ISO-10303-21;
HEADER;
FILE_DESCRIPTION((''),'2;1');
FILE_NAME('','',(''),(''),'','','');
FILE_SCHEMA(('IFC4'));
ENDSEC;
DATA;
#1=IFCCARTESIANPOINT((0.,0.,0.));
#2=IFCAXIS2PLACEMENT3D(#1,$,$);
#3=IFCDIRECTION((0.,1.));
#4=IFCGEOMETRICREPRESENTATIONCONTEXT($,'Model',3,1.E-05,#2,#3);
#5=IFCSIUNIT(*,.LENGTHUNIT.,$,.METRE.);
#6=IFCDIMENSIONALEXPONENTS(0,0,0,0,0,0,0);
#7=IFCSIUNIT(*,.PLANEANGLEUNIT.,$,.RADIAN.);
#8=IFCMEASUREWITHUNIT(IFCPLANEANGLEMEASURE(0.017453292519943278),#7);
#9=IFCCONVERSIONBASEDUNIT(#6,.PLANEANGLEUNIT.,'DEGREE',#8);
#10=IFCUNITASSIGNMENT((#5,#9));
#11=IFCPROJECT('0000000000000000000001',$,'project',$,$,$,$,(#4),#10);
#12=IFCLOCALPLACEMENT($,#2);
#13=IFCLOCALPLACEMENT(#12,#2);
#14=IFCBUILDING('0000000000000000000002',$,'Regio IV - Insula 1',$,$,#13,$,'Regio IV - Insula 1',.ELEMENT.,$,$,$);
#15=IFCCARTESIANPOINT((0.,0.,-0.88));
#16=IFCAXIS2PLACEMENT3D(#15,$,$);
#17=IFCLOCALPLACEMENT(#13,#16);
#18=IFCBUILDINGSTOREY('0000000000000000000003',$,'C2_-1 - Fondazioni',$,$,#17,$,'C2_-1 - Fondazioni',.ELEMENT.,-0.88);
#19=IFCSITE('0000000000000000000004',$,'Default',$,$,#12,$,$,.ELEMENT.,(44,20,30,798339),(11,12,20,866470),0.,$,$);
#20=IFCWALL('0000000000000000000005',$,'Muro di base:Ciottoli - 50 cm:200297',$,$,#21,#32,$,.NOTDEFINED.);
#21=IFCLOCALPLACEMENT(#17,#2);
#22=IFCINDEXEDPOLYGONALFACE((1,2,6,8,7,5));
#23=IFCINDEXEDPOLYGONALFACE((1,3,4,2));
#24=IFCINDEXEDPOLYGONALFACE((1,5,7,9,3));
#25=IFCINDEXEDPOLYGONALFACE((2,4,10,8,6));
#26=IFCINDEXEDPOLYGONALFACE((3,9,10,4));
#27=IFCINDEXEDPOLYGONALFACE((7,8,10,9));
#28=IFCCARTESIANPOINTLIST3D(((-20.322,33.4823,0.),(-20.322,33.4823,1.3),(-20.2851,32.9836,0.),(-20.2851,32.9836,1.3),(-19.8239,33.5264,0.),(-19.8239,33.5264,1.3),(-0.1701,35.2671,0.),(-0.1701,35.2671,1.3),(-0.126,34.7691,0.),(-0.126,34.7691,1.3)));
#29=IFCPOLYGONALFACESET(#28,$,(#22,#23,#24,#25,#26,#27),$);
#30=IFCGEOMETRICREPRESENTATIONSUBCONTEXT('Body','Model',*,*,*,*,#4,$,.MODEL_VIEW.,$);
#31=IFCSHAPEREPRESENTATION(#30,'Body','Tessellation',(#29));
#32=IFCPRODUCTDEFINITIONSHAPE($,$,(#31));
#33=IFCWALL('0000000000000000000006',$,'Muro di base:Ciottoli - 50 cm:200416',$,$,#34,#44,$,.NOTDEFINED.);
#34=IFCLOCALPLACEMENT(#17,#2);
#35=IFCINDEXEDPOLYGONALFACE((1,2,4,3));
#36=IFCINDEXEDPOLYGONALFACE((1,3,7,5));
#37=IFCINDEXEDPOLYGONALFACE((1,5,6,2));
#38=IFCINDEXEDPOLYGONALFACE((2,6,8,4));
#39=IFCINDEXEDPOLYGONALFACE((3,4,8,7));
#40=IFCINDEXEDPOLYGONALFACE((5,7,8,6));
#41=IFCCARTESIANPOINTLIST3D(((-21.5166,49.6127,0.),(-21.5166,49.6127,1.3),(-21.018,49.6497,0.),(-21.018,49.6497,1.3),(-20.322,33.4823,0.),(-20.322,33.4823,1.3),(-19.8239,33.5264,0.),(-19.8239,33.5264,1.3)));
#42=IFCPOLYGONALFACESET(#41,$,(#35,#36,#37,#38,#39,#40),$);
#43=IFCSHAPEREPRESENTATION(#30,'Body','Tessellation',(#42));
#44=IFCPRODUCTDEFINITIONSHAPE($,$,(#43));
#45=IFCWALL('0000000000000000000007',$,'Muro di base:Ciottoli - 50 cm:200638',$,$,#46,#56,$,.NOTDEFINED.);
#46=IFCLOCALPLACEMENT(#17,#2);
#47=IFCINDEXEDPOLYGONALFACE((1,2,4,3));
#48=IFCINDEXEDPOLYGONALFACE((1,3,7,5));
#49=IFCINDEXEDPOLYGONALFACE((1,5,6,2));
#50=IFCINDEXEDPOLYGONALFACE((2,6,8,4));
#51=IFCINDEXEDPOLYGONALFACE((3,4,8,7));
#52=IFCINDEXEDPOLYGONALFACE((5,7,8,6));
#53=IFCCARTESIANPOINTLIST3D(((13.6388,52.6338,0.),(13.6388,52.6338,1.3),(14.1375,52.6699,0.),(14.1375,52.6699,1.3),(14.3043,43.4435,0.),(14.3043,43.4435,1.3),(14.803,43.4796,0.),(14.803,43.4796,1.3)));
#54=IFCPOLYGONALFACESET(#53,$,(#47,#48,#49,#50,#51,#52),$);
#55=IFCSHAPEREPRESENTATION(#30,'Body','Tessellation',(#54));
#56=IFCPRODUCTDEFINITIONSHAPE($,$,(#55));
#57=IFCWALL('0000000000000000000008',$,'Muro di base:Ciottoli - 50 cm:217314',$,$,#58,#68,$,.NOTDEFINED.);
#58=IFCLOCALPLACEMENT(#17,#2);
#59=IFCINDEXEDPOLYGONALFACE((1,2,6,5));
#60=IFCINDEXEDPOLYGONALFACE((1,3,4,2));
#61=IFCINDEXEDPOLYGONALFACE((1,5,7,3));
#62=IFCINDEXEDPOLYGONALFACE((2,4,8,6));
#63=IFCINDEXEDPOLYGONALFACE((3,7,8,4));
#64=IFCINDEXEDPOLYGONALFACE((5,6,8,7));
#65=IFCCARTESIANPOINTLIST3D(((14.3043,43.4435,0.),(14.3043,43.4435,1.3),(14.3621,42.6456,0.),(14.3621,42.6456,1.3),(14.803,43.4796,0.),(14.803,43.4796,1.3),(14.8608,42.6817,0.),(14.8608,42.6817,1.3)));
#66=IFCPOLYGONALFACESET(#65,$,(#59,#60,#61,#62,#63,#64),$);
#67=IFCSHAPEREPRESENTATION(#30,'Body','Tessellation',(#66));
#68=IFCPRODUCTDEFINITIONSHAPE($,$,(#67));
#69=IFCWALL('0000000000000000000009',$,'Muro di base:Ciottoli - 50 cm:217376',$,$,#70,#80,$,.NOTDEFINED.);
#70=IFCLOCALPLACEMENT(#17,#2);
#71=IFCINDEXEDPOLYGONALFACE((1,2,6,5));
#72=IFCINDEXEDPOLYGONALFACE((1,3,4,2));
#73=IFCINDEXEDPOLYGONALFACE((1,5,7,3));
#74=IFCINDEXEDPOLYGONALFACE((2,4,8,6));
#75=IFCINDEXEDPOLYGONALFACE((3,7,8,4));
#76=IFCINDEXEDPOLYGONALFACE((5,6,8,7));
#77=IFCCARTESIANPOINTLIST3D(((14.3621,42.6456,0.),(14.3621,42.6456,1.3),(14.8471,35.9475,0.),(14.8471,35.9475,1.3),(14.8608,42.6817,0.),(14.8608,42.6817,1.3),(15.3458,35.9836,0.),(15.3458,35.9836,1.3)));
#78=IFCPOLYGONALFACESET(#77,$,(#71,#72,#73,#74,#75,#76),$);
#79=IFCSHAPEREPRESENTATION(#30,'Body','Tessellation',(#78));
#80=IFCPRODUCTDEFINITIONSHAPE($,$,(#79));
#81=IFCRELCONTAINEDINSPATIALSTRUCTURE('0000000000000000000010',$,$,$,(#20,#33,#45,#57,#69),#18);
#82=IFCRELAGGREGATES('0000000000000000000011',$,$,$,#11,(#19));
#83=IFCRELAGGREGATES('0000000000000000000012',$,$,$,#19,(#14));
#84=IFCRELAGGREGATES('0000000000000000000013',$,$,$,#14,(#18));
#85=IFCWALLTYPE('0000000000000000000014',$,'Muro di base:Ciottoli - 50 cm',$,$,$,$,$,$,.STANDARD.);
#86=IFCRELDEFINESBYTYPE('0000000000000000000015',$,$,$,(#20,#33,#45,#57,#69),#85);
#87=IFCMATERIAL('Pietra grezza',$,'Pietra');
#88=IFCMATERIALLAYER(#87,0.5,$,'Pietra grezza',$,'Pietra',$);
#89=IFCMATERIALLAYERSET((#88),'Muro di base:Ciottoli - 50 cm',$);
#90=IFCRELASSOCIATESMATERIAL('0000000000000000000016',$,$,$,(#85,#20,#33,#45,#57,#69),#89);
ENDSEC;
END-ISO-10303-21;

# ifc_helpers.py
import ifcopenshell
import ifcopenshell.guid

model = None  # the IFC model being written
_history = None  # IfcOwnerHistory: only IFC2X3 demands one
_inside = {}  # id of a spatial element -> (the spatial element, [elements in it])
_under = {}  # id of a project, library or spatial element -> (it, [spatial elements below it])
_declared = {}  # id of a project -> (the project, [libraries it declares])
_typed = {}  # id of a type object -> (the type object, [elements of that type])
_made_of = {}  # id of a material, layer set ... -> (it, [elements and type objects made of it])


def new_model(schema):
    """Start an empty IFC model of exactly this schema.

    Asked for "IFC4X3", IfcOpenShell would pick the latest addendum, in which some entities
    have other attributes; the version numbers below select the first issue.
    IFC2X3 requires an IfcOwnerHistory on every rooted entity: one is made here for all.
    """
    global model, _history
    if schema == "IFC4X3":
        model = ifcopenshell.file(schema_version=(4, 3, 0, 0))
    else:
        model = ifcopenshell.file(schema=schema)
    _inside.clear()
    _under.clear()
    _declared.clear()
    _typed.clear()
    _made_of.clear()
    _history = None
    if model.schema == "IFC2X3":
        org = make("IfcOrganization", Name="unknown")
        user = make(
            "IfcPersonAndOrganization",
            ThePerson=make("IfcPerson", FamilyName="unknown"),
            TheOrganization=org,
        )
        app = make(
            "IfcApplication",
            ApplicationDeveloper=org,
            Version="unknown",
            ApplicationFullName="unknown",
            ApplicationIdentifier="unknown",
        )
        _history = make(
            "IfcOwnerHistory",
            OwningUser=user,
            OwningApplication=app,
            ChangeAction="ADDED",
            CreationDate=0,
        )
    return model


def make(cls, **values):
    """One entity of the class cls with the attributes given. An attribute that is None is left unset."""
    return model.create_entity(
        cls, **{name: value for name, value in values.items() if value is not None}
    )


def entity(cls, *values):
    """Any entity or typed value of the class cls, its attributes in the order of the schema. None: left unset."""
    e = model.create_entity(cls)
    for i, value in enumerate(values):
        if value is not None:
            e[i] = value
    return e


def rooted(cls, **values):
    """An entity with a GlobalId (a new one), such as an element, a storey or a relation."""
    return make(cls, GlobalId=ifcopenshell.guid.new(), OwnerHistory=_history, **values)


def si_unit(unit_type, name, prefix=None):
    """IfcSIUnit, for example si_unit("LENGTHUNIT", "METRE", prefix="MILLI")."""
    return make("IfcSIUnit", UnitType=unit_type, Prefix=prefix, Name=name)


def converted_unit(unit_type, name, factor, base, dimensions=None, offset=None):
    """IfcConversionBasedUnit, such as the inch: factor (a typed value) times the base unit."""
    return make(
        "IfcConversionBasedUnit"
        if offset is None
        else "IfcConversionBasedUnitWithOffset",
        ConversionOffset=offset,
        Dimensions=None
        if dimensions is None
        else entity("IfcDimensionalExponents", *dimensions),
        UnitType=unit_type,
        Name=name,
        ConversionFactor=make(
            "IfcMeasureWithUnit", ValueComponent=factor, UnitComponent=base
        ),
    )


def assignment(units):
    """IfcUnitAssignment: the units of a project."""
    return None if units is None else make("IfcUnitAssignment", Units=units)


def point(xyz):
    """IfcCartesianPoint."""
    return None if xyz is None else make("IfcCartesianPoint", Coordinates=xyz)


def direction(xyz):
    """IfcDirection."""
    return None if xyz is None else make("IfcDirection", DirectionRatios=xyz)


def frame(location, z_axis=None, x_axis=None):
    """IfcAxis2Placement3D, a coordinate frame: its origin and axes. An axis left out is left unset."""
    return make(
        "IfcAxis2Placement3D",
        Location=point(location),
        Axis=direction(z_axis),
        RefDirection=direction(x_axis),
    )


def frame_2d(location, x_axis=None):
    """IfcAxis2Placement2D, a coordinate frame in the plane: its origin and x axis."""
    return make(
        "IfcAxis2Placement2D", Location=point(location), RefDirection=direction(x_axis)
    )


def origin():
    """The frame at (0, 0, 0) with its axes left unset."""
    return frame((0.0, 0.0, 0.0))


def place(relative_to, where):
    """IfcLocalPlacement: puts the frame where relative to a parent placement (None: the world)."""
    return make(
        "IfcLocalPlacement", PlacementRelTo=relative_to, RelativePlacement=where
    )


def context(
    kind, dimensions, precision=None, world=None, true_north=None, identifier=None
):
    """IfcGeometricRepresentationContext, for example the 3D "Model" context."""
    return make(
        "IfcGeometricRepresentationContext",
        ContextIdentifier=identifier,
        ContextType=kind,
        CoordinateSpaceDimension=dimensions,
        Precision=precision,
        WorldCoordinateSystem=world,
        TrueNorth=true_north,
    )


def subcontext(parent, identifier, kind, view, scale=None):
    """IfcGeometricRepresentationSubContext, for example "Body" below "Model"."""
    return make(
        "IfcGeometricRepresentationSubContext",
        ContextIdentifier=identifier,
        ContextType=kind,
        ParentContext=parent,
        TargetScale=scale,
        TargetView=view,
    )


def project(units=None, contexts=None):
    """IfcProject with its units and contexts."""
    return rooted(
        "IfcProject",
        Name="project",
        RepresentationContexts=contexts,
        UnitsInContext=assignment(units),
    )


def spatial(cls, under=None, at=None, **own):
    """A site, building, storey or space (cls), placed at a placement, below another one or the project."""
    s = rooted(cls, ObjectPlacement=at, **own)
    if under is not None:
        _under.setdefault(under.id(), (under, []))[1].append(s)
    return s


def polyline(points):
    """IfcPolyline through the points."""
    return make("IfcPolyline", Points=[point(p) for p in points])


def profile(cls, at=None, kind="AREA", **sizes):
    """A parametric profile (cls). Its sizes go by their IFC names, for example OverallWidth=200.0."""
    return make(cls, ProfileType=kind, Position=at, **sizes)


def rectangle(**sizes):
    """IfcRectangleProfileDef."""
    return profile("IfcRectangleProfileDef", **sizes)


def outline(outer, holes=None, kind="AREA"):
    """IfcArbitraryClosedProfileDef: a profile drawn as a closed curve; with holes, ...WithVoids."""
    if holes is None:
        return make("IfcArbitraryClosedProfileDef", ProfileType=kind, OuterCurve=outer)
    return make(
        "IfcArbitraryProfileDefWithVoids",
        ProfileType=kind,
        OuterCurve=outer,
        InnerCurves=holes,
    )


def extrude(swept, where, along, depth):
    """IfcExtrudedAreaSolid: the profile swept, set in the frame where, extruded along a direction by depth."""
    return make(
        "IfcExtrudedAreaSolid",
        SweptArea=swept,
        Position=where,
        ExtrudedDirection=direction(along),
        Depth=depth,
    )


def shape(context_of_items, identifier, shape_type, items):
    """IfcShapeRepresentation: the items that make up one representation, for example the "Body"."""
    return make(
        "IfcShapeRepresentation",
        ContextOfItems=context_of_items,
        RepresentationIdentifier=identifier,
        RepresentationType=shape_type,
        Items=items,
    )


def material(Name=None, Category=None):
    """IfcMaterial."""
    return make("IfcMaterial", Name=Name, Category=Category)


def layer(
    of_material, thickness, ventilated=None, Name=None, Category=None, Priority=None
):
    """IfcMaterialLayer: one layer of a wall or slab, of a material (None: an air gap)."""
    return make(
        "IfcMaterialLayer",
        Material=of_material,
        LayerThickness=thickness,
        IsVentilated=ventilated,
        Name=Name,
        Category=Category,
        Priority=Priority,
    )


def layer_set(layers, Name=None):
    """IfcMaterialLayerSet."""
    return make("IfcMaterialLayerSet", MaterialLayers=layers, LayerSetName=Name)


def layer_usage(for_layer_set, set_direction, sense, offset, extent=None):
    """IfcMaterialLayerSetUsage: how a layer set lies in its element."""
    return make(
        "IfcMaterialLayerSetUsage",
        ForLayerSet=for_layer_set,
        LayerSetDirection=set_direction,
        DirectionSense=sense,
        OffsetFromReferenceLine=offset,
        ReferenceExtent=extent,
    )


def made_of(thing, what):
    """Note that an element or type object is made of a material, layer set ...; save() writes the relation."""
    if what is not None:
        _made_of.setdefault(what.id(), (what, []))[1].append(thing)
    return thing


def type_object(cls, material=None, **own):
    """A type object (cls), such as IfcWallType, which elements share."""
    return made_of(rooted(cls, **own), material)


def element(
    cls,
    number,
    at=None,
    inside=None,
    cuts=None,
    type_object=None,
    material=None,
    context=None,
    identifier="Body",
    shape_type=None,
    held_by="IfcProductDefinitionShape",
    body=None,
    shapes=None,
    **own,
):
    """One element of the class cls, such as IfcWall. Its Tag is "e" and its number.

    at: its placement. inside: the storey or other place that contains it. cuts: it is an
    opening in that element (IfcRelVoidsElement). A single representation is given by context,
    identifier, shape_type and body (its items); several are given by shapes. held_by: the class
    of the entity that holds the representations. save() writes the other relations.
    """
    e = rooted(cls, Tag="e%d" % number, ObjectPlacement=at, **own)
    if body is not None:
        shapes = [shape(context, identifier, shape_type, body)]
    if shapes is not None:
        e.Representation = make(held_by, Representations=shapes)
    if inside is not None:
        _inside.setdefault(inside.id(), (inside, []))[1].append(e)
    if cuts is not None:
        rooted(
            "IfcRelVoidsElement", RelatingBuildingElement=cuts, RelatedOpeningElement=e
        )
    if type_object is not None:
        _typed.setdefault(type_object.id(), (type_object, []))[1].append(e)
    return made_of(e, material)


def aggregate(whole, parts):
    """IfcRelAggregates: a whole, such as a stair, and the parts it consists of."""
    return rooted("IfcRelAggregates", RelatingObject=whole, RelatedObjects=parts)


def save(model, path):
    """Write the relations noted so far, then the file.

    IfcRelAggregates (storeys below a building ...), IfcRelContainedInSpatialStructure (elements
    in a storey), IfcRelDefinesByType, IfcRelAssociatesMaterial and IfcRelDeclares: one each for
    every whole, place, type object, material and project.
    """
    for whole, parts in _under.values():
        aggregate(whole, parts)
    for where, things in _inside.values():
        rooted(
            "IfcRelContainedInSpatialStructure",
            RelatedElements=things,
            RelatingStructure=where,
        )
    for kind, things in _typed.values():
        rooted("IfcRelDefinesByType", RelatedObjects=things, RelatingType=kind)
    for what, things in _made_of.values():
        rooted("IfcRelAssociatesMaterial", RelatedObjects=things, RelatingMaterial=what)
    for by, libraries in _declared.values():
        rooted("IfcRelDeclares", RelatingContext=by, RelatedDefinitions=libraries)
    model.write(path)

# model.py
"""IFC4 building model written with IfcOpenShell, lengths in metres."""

from ifc_helpers import new_model, entity, si_unit, converted_unit, direction, frame, frame_2d, origin, place, context, subcontext, project, spatial, polyline, rectangle, outline, extrude, material, layer, layer_set, layer_usage, type_object, element, save


model = new_model("IFC4")

# Units and contexts
model_context = context("Model", 3, precision=1e-05, world=origin(), true_north=direction((0.0, 1.0)))
body_context = subcontext(model_context, "Body", "Model", "MODEL_VIEW")
ifc_project = project(units=[si_unit("LENGTHUNIT", "METRE"), converted_unit("PLANEANGLEUNIT", "DEGREE", entity("IfcPlaneAngleMeasure", 0.017453292519943278), si_unit("PLANEANGLEUNIT", "RADIAN"), dimensions=[0, 0, 0, 0, 0, 0, 0])], contexts=[model_context])

# Site, building, storey
site_placement = place(None, origin())
site = spatial("IfcSite", under=ifc_project, at=site_placement, Name="Default", CompositionType="ELEMENT", RefLatitude=(44, 20, 30, 798339), RefLongitude=(11, 12, 20, 866470), RefElevation=0.0)
building_placement = place(site_placement, origin())
building = spatial("IfcBuilding", under=site, at=building_placement, Name="Regio IV - Insula 1", LongName="Regio IV - Insula 1", CompositionType="ELEMENT")
storey_placement = place(building_placement, frame((0.0, 0.0, -0.88)))
storey = spatial("IfcBuildingStorey", under=building, at=storey_placement, Name="C2_-1 - Fondazioni", LongName="C2_-1 - Fondazioni", CompositionType="ELEMENT", Elevation=-0.88)

# Walls
ifc_material_1 = material(Name="Pietra grezza", Category="Pietra")
ifc_layer_1 = layer(ifc_material_1, 0.5, Name="Pietra grezza", Category="Pietra")
ifc_layer_set_1 = layer_set([ifc_layer_1], Name="Muro di base:Ciottoli - 50 cm")
wall_type_1 = type_object("IfcWallType", Name="Muro di base:Ciottoli - 50 cm", PredefinedType="STANDARD", material=ifc_layer_set_1)
ifc_layer_usage_1 = layer_usage(ifc_layer_set_1, "AXIS2", "NEGATIVE", 0.25)
wall_1_placement = place(storey_placement, frame((-0.148, 35.0181, 0.0), z_axis=(0.0, 0.0, 1.0), x_axis=(-0.996101, -0.088225, 0.0)))
element("IfcWall", 1, at=wall_1_placement, inside=storey, type_object=wall_type_1, material=ifc_layer_usage_1, Name="Muro di base:Ciottoli - 50 cm:200297", PredefinedType="NOTDEFINED", context=body_context, shape_type="SweptSolid", body=[
    extrude(outline(polyline([(20.2308, -0.25), (20.238, 0.25), (0.0, 0.25), (0.0, -0.25), (19.7307, -0.25), (20.2308, -0.25)])), origin(), (0.0, 0.0, 1.0), 1.3),
])
ifc_layer_usage_2 = layer_usage(ifc_layer_set_1, "AXIS2", "NEGATIVE", 0.25)
wall_2_placement = place(storey_placement, frame((-20.0727, 33.5007, 0.0), z_axis=(0.0, 0.0, 1.0), x_axis=(-0.073857, 0.997269, 0.0)))
element("IfcWall", 2, at=wall_2_placement, inside=storey, type_object=wall_type_1, material=ifc_layer_usage_2, Name="Muro di base:Ciottoli - 50 cm:200416", PredefinedType="NOTDEFINED", context=body_context, shape_type="SweptSolid", body=[
    extrude(outline(polyline([(16.1746, -0.25), (16.1746, 0.25), (0.0, 0.25), (0.0072, -0.25), (16.1746, -0.25)])), origin(), (0.0, 0.0, 1.0), 1.3),
])
ifc_layer_usage_3 = layer_usage(ifc_layer_set_1, "AXIS2", "NEGATIVE", 0.25)
wall_3_placement = place(storey_placement, frame((13.8882, 52.6518, 0.0), z_axis=(0.0, 0.0, 1.0), x_axis=(0.07222, -0.997389, 0.0)))
element("IfcWall", 3, at=wall_3_placement, inside=storey, type_object=wall_type_1, material=ifc_layer_usage_3, Name="Muro di base:Ciottoli - 50 cm:200638", PredefinedType="NOTDEFINED", context=body_context, shape_type="SweptSolid", body=[
    extrude(rectangle(XDim=9.2144, YDim=0.5, at=frame_2d((4.6072, 0.0), x_axis=(-1.0, 0.0))), origin(), (0.0, 0.0, 1.0), 1.3),
])
ifc_layer_usage_4 = layer_usage(ifc_layer_set_1, "AXIS2", "NEGATIVE", 0.25)
wall_4_placement = place(storey_placement, frame((14.5536, 43.4616, 0.0), z_axis=(0.0, 0.0, 1.0), x_axis=(0.07222, -0.997389, 0.0)))
element("IfcWall", 4, at=wall_4_placement, inside=storey, type_object=wall_type_1, material=ifc_layer_usage_4, Name="Muro di base:Ciottoli - 50 cm:217314", PredefinedType="NOTDEFINED", context=body_context, shape_type="SweptSolid", body=[
    extrude(rectangle(XDim=0.8, YDim=0.5, at=frame_2d((0.4, 0.0), x_axis=(-1.0, 0.0))), origin(), (0.0, 0.0, 1.0), 1.3),
])
ifc_layer_usage_5 = layer_usage(ifc_layer_set_1, "AXIS2", "NEGATIVE", 0.25)
wall_5_placement = place(storey_placement, frame((14.6114, 42.6636, 0.0), z_axis=(0.0, 0.0, 1.0), x_axis=(0.07222, -0.997389, 0.0)))
element("IfcWall", 5, at=wall_5_placement, inside=storey, type_object=wall_type_1, material=ifc_layer_usage_5, Name="Muro di base:Ciottoli - 50 cm:217376", PredefinedType="NOTDEFINED", context=body_context, shape_type="SweptSolid", body=[
    extrude(rectangle(XDim=6.7157, YDim=0.5, at=frame_2d((3.3578, 0.0), x_axis=(-1.0, 0.0))), origin(), (0.0, 0.0, 1.0), 1.3),
])

save(model, "model.ifc")
